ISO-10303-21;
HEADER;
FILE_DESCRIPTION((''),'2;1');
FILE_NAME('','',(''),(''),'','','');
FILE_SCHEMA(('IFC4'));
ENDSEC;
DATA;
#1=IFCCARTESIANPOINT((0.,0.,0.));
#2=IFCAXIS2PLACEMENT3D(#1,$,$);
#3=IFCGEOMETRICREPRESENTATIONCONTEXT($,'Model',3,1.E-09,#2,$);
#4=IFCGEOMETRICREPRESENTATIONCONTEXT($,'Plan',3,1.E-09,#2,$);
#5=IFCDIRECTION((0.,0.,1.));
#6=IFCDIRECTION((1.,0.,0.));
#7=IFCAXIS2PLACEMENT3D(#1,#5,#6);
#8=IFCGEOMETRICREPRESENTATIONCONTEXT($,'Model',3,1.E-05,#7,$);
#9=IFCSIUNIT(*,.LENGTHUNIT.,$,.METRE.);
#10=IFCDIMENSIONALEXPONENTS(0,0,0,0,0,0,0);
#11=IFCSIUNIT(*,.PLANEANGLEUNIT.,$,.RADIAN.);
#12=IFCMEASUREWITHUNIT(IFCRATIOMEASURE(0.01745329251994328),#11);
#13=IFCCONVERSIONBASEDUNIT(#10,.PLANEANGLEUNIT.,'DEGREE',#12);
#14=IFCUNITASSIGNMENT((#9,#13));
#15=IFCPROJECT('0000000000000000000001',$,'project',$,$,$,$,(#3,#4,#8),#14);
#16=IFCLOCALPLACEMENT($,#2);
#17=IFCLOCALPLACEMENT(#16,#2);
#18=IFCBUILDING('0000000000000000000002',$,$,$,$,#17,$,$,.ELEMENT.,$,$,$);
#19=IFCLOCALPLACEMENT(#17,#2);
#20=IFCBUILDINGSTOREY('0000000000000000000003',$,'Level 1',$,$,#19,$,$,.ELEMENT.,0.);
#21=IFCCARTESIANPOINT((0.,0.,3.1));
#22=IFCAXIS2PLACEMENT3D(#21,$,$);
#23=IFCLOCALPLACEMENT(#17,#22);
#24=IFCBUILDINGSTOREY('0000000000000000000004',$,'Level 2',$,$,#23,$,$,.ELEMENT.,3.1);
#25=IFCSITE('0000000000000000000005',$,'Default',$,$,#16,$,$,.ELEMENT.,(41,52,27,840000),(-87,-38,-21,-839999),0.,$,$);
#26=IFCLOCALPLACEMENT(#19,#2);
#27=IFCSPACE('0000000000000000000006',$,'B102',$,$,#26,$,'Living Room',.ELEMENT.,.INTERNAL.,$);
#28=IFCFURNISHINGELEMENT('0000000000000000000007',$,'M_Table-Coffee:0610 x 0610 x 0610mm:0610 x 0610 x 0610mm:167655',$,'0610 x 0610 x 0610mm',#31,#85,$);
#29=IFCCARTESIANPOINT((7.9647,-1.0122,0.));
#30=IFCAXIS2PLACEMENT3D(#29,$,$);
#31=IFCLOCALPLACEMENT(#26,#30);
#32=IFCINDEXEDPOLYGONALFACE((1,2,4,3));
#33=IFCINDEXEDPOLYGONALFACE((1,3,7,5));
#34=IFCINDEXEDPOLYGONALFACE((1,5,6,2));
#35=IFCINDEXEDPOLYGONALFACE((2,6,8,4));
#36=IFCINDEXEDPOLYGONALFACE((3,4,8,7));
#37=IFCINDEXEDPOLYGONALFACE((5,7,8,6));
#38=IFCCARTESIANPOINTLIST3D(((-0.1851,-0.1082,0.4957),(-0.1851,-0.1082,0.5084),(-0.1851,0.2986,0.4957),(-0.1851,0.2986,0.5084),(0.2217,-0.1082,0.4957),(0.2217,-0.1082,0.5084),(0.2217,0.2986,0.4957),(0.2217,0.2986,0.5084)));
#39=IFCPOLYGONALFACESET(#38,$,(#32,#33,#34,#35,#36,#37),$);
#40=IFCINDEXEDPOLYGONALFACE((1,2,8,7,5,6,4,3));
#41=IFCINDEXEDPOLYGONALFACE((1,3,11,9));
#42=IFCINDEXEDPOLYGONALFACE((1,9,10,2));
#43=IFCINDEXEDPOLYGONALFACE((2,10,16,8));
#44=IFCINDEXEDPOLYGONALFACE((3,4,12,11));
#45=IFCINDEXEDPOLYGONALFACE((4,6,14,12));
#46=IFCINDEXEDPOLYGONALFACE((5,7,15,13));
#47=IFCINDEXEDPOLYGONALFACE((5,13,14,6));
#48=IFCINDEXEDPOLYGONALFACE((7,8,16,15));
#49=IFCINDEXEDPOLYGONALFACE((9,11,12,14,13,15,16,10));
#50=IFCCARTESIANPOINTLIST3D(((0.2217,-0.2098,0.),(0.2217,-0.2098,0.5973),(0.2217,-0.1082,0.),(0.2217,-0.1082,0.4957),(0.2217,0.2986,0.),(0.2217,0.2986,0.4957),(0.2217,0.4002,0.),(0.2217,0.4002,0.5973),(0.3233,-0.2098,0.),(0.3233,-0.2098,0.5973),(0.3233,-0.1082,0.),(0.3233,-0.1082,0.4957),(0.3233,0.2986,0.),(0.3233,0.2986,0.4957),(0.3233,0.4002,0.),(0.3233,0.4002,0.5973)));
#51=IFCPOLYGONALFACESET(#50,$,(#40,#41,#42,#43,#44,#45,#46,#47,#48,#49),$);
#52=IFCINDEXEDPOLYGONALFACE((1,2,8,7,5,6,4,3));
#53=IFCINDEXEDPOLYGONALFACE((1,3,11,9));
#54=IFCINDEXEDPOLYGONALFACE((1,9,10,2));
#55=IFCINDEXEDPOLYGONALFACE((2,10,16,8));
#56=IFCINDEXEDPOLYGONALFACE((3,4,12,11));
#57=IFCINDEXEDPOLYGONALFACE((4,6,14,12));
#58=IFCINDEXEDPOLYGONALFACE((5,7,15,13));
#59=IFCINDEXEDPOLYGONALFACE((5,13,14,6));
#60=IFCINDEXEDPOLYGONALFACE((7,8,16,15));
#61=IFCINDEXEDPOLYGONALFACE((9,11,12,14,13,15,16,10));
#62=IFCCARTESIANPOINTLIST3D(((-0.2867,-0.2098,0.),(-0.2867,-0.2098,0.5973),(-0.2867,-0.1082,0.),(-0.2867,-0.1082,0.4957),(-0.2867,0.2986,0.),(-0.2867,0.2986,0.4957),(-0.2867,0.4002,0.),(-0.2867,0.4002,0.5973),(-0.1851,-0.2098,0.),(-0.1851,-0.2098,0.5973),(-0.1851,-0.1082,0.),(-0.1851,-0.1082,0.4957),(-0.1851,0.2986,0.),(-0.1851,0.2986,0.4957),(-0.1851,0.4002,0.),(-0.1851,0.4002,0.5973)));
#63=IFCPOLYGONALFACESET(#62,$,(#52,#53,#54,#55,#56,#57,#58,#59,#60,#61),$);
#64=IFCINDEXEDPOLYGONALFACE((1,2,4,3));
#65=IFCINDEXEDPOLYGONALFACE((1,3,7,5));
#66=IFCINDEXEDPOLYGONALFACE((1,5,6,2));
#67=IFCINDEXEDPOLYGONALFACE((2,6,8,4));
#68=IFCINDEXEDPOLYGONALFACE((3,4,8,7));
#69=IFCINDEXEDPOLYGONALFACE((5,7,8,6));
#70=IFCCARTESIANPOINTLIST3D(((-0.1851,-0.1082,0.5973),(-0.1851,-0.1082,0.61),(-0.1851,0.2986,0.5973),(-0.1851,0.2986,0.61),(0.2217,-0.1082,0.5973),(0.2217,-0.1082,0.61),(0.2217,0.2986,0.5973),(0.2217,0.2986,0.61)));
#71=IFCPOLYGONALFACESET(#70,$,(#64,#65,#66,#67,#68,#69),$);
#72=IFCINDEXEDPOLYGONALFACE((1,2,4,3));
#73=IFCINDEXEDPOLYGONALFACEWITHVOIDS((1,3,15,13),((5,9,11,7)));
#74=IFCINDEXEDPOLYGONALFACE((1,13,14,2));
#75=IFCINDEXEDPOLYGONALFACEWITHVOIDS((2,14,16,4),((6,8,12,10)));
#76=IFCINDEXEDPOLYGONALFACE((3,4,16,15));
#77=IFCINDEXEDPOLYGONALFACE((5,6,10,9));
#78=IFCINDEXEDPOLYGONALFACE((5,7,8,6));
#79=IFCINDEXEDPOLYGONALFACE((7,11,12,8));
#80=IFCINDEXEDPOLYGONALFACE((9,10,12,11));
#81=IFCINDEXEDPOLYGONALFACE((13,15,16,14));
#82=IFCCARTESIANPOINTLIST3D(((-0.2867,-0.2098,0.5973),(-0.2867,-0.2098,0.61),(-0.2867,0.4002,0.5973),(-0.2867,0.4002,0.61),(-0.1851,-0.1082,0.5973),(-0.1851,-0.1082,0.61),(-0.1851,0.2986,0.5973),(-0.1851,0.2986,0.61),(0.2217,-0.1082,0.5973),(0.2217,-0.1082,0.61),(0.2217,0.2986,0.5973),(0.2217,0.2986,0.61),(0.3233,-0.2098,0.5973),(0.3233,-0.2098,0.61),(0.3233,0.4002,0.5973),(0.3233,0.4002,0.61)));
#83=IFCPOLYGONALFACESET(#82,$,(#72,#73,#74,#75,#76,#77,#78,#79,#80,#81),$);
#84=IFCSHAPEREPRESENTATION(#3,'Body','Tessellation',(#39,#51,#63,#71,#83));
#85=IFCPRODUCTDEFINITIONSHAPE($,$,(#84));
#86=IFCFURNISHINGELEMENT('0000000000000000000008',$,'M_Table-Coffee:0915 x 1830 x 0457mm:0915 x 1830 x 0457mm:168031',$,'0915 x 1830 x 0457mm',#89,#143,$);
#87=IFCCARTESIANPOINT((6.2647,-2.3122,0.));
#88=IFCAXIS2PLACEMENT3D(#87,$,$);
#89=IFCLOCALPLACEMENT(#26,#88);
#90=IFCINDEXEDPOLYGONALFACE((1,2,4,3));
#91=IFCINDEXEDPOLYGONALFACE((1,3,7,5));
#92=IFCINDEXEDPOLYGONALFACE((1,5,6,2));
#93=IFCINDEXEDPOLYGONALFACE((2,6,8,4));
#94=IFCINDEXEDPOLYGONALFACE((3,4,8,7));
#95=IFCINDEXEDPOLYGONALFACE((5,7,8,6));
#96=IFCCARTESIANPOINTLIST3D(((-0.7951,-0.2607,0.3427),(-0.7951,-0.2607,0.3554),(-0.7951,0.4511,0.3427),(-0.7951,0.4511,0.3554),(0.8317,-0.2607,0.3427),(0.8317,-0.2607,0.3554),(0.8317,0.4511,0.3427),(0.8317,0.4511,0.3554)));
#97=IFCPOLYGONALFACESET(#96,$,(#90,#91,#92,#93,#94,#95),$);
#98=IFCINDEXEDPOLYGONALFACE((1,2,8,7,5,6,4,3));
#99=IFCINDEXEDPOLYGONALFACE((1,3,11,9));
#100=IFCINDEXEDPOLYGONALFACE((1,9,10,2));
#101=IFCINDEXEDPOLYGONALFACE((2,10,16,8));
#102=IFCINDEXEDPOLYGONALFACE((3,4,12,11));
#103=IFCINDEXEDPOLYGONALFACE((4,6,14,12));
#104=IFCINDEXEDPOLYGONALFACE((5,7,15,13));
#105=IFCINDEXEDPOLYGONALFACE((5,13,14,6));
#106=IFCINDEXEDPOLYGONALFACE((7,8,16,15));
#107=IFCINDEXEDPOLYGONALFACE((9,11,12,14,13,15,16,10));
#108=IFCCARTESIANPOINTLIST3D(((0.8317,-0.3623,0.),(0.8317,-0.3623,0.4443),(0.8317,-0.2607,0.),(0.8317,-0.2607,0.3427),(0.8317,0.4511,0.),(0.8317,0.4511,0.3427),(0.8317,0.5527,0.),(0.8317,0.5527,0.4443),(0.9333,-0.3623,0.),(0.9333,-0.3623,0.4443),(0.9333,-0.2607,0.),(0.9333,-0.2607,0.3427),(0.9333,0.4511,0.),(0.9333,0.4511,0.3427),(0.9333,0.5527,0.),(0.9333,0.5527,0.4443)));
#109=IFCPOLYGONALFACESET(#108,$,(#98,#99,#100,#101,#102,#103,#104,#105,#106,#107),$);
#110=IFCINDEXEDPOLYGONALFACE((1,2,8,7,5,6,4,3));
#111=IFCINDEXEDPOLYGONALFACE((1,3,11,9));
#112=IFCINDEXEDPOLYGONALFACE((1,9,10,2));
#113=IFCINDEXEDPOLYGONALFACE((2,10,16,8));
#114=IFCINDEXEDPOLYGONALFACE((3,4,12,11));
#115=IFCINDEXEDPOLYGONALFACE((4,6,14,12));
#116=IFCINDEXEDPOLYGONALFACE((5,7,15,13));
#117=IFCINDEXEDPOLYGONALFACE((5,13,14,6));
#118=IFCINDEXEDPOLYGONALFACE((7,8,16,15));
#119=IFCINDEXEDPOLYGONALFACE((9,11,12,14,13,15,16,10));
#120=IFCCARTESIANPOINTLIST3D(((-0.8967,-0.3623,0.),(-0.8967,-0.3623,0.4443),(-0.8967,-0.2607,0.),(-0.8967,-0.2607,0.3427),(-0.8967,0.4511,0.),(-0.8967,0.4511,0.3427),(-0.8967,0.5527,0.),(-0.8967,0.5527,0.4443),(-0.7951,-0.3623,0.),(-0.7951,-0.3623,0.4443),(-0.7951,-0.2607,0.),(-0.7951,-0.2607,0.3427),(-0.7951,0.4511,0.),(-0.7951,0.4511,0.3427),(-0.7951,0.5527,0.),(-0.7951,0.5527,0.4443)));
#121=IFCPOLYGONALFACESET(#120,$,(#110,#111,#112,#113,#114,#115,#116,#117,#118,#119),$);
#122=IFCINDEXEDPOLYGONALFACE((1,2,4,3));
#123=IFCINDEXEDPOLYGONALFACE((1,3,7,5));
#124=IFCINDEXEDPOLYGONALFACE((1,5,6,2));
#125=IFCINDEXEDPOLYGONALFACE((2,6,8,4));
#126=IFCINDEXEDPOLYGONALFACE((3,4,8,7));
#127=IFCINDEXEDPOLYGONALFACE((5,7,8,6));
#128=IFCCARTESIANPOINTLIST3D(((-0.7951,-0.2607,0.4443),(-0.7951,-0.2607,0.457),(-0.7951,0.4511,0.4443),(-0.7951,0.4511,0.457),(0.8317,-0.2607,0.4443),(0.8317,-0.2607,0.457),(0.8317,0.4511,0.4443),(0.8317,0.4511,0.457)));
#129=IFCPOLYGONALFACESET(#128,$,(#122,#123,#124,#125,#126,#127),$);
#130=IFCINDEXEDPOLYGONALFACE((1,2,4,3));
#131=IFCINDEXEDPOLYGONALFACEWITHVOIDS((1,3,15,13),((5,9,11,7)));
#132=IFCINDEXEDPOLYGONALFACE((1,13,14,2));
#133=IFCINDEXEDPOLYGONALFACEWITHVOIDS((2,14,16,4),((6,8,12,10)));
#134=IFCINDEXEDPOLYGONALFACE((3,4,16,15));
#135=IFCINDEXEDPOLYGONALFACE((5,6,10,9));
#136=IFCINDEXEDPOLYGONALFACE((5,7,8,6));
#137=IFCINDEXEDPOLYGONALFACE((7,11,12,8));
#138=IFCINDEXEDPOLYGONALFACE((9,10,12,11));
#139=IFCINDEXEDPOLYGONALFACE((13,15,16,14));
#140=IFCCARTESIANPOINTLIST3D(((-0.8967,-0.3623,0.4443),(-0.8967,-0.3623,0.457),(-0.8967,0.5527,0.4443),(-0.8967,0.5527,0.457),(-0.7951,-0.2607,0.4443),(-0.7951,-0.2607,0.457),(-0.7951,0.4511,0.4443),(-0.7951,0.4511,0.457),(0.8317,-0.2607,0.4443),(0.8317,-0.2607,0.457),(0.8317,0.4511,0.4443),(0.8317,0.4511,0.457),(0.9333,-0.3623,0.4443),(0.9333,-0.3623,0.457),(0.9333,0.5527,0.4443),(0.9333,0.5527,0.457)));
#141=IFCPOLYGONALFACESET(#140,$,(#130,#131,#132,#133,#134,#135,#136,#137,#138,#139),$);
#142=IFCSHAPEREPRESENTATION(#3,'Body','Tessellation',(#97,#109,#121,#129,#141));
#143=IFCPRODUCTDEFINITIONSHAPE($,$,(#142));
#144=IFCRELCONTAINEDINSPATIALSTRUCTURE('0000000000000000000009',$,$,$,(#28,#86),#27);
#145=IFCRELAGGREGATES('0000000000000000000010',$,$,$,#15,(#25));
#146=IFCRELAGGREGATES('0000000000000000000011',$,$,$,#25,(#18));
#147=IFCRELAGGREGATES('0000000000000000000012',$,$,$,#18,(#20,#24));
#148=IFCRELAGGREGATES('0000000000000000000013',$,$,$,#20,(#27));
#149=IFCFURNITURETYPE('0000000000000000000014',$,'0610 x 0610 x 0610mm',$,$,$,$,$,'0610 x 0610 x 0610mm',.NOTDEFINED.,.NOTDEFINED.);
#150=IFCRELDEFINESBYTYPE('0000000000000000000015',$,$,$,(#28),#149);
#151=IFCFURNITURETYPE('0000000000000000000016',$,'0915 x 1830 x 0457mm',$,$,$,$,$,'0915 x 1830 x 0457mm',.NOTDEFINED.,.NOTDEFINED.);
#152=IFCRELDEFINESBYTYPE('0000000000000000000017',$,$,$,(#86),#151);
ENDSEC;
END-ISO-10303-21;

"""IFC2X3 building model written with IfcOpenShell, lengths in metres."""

from ifc_helpers import new_model, entity, si_unit, converted_unit, frame, origin, origin_with_axes, origin_2d_with_axis, place, context, project, spatial, polyline, rectangle, outline, extrude, source, transform, mapped, type_object, type_shapes, element, save


model = new_model("IFC2X3")

# Units and contexts
model_context_1 = context("Model", 3, precision=1e-09, world=origin())
plan_context = context("Plan", 3, precision=1e-09, world=origin())
model_context_2 = context("Model", 3, precision=1e-05, world=origin_with_axes())
ifc_project = project(units=[si_unit("LENGTHUNIT", "METRE"), converted_unit("PLANEANGLEUNIT", "DEGREE", entity("IfcRatioMeasure", 0.01745329251994328), si_unit("PLANEANGLEUNIT", "RADIAN"), dimensions=[0, 0, 0, 0, 0, 0, 0])], contexts=[model_context_1, plan_context, model_context_2])

# Site, building, storey
site_placement = place(None, origin())
site = spatial("IfcSite", under=ifc_project, at=site_placement, Name="Default", CompositionType="ELEMENT", RefLatitude=(41, 52, 27, 840000), RefLongitude=(-87, -38, -21, -839999), RefElevation=0.0)
building_placement = place(site_placement, origin())
building = spatial("IfcBuilding", under=site, at=building_placement, CompositionType="ELEMENT")
storey_1_placement = place(building_placement, origin())
storey_1 = spatial("IfcBuildingStorey", under=building, at=storey_1_placement, Name="Level 1", CompositionType="ELEMENT", Elevation=0.0)

# Shared definitions
storey_2_placement = place(building_placement, frame((0.0, 0.0, 3.1)))
storey_2 = spatial("IfcBuildingStorey", under=building, at=storey_2_placement, Name="Level 2", CompositionType="ELEMENT", Elevation=3.1)

# Shared definitions
space_1_placement = place(storey_1_placement, origin())
space_1 = spatial("IfcSpace", under=storey_1, at=space_1_placement, Name="B102", LongName="Living Room", CompositionType="ELEMENT", InteriorOrExteriorSpace="INTERNAL")

# Furnishing elements
furniture_type_1 = type_object("IfcFurnitureType", Name="0610 x 0610 x 0610mm", ElementType="0610 x 0610 x 0610mm", AssemblyPlace="NOTDEFINED")
shared_shape_1 = source(origin(), model_context_1, "Body", "SweptSolid", [
    extrude(rectangle(XDim=0.4068, YDim=0.4068, at=origin_2d_with_axis()), frame((0.0183, 0.0952, 0.4957), z_axis=(0.0, 0.0, 1.0), x_axis=(-1.0, 0.0, 0.0)), (0.0, 0.0, 1.0), 0.0127),
    extrude(outline(polyline([(-0.2732, -0.305), (0.324, -0.305), (0.324, 0.305), (-0.2732, 0.305), (-0.2732, 0.2034), (0.2225, 0.2034), (0.2225, -0.2034), (-0.2732, -0.2034), (-0.2732, -0.305)])), frame((0.2217, 0.0952, 0.2732), z_axis=(1.0, 0.0, 0.0), x_axis=(0.0, 0.0, 1.0)), (0.0, 0.0, 1.0), 0.1016),
    extrude(outline(polyline([(-0.305, -0.3241), (0.305, -0.3241), (0.305, 0.2733), (0.2034, 0.2733), (0.2034, -0.2224), (-0.2034, -0.2224), (-0.2034, 0.2733), (-0.305, 0.2733), (-0.305, -0.3241)])), frame((-0.2867, 0.0952, 0.2733), z_axis=(1.0, 0.0, 0.0), x_axis=(0.0, -1.0, 0.0)), (0.0, 0.0, 1.0), 0.1016),
    extrude(rectangle(XDim=0.4068, YDim=0.4068, at=origin_2d_with_axis()), frame((0.0183, 0.0952, 0.5973), z_axis=(0.0, 0.0, 1.0), x_axis=(-1.0, 0.0, 0.0)), (0.0, 0.0, 1.0), 0.0127),
    extrude(outline(polyline([(-0.305, -0.305), (0.305, -0.305), (0.305, 0.305), (-0.305, 0.305), (-0.305, -0.305)]), holes=[polyline([(-0.2034, -0.2034), (-0.2034, 0.2034), (0.2034, 0.2034), (0.2034, -0.2034), (-0.2034, -0.2034)])]), frame((0.0183, 0.0952, 0.5973), z_axis=(0.0, 0.0, 1.0), x_axis=(-1.0, 0.0, 0.0)), (0.0, 0.0, 1.0), 0.0127),
])
type_shapes(furniture_type_1, [shared_shape_1])
for number, where, name in (
    (1, (7.9647, -1.0122, 0.0), "M_Table-Coffee:0610 x 0610 x 0610mm:0610 x 0610 x 0610mm:167655"),
):
    element("IfcFurnishingElement", number, at=place(space_1_placement, frame(where)), inside=space_1, type_object=furniture_type_1, Name=name, ObjectType="0610 x 0610 x 0610mm", context=model_context_1, shape_type="MappedRepresentation", body=[
        mapped(shared_shape_1, transform((0.0, 0.0, 0.0), scale=1.0)),
    ])
furniture_type_2 = type_object("IfcFurnitureType", Name="0915 x 1830 x 0457mm", ElementType="0915 x 1830 x 0457mm", AssemblyPlace="NOTDEFINED")
shared_shape_2 = source(origin(), model_context_1, "Body", "SweptSolid", [
    extrude(rectangle(XDim=1.6268, YDim=0.7118, at=origin_2d_with_axis()), frame((0.0183, 0.0952, 0.3427), z_axis=(0.0, 0.0, 1.0), x_axis=(-1.0, 0.0, 0.0)), (0.0, 0.0, 1.0), 0.0127),
    extrude(outline(polyline([(-0.1967, -0.4575), (0.2475, -0.4575), (0.2475, 0.4575), (-0.1967, 0.4575), (-0.1967, 0.3559), (0.146, 0.3559), (0.146, -0.3559), (-0.1967, -0.3559), (-0.1967, -0.4575)])), frame((0.8317, 0.0952, 0.1967), z_axis=(1.0, 0.0, 0.0), x_axis=(0.0, 0.0, 1.0)), (0.0, 0.0, 1.0), 0.1016),
    extrude(outline(polyline([(-0.4575, -0.2476), (0.4575, -0.2476), (0.4575, 0.1968), (0.3559, 0.1968), (0.3559, -0.1459), (-0.3559, -0.1459), (-0.3559, 0.1968), (-0.4575, 0.1968), (-0.4575, -0.2476)])), frame((-0.8967, 0.0952, 0.1968), z_axis=(1.0, 0.0, 0.0), x_axis=(0.0, -1.0, 0.0)), (0.0, 0.0, 1.0), 0.1016),
    extrude(rectangle(XDim=1.6268, YDim=0.7118, at=origin_2d_with_axis()), frame((0.0183, 0.0952, 0.4443), z_axis=(0.0, 0.0, 1.0), x_axis=(-1.0, 0.0, 0.0)), (0.0, 0.0, 1.0), 0.0127),
    extrude(outline(polyline([(-0.915, -0.4575), (0.915, -0.4575), (0.915, 0.4575), (-0.915, 0.4575), (-0.915, -0.4575)]), holes=[polyline([(-0.8134, -0.3559), (-0.8134, 0.3559), (0.8134, 0.3559), (0.8134, -0.3559), (-0.8134, -0.3559)])]), frame((0.0183, 0.0952, 0.4443), z_axis=(0.0, 0.0, 1.0), x_axis=(-1.0, 0.0, 0.0)), (0.0, 0.0, 1.0), 0.0127),
])
type_shapes(furniture_type_2, [shared_shape_2])
furnishing_1_placement = place(space_1_placement, frame((6.2647, -2.3122, 0.0)))
element("IfcFurnishingElement", 2, at=furnishing_1_placement, inside=space_1, type_object=furniture_type_2, Name="M_Table-Coffee:0915 x 1830 x 0457mm:0915 x 1830 x 0457mm:168031", ObjectType="0915 x 1830 x 0457mm", context=model_context_1, shape_type="MappedRepresentation", body=[
    mapped(shared_shape_2, transform((0.0, 0.0, 0.0), scale=1.0)),
])

save(model, "model.ifc")
